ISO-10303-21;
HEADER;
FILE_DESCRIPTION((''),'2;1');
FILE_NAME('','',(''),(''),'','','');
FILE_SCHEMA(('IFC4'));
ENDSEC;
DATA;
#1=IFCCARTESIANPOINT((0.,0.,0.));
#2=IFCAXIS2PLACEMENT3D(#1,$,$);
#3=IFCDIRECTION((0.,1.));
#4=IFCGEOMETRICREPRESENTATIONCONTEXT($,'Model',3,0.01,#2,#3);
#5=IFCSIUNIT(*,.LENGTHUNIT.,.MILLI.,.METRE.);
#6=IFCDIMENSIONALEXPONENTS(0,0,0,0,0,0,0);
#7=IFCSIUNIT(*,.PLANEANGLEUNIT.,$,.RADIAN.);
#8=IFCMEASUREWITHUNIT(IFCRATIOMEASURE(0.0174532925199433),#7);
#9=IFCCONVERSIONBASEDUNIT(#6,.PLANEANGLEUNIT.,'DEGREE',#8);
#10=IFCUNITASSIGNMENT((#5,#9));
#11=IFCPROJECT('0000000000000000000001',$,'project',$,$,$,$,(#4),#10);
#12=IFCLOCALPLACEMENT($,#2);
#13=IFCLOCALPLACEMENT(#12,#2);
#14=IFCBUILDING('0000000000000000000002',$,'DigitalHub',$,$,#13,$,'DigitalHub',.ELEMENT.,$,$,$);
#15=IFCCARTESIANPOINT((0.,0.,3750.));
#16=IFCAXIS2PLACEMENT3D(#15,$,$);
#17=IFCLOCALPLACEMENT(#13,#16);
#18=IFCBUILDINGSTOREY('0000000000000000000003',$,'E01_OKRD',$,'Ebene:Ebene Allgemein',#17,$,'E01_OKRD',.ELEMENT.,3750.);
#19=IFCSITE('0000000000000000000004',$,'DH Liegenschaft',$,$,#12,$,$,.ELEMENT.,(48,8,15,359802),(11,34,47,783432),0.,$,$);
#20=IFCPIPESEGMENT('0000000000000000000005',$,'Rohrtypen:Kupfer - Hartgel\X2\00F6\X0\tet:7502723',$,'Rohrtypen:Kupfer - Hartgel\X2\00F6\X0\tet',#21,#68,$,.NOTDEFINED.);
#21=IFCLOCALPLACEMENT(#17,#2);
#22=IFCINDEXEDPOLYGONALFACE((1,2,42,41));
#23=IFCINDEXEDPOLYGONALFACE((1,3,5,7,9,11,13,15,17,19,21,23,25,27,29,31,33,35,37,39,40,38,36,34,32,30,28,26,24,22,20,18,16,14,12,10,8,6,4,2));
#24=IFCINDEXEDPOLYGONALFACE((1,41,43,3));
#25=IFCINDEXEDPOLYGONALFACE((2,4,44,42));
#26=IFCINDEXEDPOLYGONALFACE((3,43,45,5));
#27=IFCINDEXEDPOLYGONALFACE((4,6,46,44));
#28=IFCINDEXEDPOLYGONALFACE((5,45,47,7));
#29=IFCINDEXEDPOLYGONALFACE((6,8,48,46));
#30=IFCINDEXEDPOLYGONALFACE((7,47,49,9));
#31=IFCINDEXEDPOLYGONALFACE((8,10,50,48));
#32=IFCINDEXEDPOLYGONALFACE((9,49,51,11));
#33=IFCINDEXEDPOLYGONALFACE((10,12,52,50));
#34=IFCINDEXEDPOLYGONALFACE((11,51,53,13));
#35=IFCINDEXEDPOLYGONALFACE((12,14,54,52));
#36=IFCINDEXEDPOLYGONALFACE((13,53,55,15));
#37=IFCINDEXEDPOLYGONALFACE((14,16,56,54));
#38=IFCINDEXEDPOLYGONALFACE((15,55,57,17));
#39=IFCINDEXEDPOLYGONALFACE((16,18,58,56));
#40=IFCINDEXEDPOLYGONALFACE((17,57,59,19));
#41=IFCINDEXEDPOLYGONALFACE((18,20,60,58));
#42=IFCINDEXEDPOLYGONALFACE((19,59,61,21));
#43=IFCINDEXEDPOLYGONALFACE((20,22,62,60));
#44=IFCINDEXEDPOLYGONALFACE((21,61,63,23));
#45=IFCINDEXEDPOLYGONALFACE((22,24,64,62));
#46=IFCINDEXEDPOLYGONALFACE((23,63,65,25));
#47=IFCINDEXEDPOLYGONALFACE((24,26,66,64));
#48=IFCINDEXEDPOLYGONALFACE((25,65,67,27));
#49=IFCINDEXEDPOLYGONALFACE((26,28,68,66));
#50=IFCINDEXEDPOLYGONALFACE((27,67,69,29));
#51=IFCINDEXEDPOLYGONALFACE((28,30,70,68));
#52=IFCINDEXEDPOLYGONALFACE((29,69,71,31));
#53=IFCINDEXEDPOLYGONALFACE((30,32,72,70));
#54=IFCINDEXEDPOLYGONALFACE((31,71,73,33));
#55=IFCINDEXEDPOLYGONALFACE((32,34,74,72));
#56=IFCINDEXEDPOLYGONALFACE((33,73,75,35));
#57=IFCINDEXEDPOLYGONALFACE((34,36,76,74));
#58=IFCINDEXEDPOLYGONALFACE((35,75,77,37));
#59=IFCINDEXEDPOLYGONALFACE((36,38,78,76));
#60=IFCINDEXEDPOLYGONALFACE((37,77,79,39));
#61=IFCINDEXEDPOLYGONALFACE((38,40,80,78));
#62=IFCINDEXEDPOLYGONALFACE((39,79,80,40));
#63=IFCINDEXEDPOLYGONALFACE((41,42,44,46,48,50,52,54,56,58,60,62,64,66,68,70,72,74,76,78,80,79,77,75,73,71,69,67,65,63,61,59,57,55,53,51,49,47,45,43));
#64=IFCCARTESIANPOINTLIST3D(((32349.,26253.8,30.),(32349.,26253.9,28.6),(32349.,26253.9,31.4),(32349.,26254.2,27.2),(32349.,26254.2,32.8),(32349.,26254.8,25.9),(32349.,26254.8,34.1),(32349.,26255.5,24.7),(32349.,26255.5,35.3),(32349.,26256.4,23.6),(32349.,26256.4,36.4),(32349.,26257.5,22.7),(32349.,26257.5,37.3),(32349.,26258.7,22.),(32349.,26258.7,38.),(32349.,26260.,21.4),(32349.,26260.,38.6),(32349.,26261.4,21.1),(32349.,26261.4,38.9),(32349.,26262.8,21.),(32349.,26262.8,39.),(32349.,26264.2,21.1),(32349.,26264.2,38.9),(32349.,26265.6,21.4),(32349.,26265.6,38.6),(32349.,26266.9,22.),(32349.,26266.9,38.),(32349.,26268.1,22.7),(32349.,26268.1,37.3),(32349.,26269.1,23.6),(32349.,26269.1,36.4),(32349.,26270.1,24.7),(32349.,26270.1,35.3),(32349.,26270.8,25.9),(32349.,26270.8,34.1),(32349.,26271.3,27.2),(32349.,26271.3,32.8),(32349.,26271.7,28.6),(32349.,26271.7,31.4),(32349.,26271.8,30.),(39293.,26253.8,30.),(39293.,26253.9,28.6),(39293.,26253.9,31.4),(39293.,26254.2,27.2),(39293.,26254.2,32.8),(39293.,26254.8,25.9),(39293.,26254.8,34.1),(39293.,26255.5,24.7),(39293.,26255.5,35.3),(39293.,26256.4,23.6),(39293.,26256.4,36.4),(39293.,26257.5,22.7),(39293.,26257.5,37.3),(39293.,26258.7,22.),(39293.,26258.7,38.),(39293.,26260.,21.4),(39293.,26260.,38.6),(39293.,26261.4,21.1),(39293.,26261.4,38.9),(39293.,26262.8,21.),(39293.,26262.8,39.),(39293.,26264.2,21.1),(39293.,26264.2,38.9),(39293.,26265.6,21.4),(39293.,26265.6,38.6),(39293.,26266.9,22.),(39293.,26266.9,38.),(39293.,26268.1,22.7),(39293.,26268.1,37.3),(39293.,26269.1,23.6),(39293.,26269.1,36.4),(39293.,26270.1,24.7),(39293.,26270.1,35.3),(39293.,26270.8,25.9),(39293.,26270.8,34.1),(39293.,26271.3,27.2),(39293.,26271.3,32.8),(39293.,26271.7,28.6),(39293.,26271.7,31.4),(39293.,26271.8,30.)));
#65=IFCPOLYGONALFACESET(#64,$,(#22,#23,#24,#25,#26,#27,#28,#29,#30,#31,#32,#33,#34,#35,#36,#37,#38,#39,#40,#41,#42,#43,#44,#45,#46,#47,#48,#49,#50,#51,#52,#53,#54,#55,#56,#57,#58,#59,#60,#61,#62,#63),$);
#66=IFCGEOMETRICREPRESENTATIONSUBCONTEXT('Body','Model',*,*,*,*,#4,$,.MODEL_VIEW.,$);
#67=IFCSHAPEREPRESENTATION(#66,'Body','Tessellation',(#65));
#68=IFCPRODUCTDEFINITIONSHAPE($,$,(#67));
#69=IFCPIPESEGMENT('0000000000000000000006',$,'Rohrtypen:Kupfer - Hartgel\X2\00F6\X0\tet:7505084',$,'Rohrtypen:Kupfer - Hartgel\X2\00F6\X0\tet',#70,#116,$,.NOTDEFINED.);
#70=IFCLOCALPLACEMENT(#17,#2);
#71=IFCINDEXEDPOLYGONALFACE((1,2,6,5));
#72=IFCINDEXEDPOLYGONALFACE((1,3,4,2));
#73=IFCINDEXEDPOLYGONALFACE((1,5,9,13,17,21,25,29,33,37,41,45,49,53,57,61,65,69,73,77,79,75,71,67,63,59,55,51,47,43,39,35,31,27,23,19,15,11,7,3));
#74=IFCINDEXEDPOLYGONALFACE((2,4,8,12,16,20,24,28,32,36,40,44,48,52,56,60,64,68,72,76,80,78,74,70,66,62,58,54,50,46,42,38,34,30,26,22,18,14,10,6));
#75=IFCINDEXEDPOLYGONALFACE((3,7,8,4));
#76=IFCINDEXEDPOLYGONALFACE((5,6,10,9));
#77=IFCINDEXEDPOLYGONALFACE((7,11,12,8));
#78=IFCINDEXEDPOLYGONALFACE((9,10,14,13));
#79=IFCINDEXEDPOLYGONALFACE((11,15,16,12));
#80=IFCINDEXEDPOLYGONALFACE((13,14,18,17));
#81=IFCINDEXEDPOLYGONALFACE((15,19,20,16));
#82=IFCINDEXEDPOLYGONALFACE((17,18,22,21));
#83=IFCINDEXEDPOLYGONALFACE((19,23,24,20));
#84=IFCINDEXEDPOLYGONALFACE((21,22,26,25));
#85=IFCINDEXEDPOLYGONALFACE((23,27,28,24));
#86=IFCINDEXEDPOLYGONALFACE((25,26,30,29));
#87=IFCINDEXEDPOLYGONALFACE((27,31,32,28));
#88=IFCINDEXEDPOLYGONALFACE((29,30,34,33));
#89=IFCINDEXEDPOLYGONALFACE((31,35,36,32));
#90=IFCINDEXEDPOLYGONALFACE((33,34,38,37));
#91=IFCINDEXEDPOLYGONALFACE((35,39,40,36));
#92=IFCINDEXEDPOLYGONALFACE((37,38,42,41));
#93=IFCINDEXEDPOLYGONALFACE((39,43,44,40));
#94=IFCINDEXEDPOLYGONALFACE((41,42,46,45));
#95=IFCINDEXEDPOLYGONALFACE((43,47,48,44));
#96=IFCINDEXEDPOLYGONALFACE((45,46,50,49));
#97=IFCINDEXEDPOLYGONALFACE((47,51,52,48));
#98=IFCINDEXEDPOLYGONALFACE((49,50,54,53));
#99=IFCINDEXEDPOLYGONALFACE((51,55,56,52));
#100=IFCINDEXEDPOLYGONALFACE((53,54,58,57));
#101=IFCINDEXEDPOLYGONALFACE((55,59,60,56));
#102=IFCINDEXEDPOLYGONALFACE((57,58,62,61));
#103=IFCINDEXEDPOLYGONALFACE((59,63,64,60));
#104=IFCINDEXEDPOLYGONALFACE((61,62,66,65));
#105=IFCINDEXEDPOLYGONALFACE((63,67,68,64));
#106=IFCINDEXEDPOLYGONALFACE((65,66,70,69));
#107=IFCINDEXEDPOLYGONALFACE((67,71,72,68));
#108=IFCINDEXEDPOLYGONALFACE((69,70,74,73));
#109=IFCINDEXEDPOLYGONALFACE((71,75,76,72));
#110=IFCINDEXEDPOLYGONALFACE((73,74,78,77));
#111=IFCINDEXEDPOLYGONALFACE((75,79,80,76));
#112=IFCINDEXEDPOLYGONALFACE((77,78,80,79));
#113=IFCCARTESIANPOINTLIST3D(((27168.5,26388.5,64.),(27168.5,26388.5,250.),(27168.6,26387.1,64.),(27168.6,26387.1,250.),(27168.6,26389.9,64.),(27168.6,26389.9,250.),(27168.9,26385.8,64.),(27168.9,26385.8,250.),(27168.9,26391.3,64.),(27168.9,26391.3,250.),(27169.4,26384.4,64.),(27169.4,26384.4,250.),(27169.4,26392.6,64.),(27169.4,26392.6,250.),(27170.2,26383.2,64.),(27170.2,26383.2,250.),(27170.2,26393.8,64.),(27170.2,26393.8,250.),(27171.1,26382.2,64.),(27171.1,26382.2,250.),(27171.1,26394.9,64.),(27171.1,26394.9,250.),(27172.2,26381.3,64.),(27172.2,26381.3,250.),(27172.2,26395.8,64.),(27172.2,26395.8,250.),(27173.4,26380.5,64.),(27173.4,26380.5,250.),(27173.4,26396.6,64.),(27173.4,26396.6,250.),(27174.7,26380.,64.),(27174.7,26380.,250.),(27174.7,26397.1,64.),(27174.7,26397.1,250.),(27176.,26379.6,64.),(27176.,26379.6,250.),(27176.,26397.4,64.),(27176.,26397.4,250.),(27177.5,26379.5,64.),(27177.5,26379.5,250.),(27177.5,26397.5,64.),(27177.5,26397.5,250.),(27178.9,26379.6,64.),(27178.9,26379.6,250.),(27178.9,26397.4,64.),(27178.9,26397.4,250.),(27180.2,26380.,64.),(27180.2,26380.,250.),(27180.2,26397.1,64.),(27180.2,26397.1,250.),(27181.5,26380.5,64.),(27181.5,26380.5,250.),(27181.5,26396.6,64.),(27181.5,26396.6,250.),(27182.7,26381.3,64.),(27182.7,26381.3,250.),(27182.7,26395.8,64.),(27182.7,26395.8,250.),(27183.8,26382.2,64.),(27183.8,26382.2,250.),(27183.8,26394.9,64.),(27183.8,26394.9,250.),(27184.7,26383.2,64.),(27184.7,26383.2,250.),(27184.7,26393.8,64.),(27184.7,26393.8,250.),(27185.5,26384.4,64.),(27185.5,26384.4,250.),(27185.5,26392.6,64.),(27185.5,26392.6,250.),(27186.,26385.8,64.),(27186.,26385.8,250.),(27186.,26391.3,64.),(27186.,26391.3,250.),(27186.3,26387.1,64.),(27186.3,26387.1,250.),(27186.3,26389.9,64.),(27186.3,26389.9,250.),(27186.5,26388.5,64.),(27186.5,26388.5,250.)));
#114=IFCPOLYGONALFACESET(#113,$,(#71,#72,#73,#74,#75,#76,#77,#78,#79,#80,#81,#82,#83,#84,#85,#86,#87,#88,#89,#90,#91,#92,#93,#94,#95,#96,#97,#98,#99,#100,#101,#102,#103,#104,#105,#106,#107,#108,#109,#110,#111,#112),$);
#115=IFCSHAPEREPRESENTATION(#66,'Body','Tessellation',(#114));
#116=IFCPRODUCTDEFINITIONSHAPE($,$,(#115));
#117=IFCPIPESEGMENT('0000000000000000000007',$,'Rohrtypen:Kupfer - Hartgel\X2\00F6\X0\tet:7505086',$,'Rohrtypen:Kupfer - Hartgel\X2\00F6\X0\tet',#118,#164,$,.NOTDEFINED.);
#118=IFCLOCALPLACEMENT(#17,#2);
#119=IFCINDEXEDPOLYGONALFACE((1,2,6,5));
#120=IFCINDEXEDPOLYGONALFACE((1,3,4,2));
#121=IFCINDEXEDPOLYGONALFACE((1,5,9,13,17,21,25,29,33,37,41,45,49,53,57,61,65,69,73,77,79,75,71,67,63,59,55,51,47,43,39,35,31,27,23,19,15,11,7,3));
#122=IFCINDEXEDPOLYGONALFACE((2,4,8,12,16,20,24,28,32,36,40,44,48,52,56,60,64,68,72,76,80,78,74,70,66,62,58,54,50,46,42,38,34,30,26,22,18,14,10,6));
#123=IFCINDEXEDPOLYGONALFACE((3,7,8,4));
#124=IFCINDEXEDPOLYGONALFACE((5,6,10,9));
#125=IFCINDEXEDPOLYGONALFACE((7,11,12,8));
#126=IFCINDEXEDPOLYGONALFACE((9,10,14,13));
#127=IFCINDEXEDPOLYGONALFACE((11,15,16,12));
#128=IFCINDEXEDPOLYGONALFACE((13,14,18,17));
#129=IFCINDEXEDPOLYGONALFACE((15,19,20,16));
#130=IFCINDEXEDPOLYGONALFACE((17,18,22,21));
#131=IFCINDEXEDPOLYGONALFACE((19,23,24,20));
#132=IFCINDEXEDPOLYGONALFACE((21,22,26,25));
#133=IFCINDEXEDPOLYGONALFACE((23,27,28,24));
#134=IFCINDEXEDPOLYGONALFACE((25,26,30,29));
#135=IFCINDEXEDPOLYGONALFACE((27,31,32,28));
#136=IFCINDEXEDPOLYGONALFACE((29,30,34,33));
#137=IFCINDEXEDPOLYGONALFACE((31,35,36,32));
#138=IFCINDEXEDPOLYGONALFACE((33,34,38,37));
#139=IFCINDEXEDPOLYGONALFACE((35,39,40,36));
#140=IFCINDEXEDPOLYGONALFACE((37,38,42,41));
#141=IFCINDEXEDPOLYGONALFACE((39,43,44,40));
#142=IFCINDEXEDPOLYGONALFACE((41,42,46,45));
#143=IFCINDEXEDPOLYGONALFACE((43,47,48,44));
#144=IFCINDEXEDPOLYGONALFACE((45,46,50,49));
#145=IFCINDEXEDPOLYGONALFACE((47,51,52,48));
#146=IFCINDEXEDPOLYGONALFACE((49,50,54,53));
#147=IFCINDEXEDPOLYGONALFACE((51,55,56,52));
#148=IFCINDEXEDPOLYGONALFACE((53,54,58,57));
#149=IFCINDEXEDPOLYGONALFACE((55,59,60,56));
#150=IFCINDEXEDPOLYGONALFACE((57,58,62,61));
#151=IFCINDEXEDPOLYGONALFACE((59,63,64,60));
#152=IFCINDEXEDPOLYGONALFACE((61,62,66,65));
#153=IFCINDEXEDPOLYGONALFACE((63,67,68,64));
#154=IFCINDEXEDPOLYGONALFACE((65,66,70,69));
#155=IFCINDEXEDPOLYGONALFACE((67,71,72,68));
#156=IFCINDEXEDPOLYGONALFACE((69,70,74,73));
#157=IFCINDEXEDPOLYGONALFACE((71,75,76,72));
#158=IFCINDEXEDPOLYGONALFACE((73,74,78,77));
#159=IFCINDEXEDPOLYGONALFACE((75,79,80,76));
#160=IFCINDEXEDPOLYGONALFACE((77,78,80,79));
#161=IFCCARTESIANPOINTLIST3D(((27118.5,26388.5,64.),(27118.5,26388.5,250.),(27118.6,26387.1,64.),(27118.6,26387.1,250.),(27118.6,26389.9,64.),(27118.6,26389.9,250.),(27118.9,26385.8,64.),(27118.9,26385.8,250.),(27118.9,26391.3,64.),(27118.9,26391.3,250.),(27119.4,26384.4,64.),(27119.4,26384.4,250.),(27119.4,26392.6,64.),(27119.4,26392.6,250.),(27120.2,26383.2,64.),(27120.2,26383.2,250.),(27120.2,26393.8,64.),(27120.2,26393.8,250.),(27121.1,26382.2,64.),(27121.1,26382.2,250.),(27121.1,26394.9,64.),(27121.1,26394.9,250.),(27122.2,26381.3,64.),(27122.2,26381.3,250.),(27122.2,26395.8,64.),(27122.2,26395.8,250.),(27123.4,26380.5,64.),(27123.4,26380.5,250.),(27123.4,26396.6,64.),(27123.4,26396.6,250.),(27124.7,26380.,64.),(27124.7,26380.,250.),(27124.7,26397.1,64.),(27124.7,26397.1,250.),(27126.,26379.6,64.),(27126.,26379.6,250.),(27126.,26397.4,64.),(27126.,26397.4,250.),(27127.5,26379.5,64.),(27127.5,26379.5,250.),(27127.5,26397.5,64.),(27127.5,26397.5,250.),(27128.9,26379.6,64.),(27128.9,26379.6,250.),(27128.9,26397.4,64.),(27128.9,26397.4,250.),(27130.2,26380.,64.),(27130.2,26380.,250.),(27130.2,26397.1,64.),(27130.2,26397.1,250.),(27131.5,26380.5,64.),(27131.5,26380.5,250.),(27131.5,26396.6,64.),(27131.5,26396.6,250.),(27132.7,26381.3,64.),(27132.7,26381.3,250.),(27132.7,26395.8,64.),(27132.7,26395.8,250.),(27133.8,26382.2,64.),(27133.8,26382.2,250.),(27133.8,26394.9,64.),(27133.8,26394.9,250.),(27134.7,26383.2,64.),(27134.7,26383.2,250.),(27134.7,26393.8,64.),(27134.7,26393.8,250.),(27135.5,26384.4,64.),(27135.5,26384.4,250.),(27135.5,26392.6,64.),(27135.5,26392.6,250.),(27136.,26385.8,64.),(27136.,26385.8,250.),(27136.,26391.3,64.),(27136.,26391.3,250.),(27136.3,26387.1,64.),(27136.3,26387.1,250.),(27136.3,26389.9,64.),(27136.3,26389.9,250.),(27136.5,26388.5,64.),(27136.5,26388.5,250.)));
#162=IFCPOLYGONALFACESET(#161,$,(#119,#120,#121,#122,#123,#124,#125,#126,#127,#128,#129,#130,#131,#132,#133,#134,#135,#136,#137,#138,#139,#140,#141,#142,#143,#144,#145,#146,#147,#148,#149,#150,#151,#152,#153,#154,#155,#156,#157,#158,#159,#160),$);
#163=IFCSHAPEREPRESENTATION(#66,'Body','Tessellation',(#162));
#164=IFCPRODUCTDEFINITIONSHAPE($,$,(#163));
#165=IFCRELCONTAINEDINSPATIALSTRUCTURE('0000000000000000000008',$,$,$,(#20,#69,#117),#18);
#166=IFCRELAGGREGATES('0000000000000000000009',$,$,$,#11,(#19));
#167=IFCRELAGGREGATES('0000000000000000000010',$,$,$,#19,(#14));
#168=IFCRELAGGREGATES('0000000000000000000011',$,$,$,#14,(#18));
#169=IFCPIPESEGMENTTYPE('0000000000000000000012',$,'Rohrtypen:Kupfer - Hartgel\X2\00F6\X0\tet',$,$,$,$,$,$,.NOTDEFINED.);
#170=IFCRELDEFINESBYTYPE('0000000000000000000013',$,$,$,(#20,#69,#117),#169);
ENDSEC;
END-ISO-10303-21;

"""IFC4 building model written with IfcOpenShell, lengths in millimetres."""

from ifc_helpers import new_model, entity, si_unit, converted_unit, direction, frame, origin, place, context, subcontext, project, spatial, indexed_curve, outline, extrude, type_object, element, save


model = new_model("IFC4")

# Units and contexts
model_context = context("Model", 3, precision=0.01, world=origin(), true_north=direction((0.0, 1.0)))
body_context = subcontext(model_context, "Body", "Model", "MODEL_VIEW")
ifc_project = project(units=[si_unit("LENGTHUNIT", "METRE", prefix="MILLI"), converted_unit("PLANEANGLEUNIT", "DEGREE", entity("IfcRatioMeasure", 0.0174532925199433), si_unit("PLANEANGLEUNIT", "RADIAN"), dimensions=[0, 0, 0, 0, 0, 0, 0])], contexts=[model_context])

# Site, building, storey
site_placement = place(None, origin())
site = spatial("IfcSite", under=ifc_project, at=site_placement, Name="DH Liegenschaft", CompositionType="ELEMENT", RefLatitude=(48, 8, 15, 359802), RefLongitude=(11, 34, 47, 783432), RefElevation=0.0)
building_placement = place(site_placement, origin())
building = spatial("IfcBuilding", under=site, at=building_placement, Name="DigitalHub", LongName="DigitalHub", CompositionType="ELEMENT")
storey_placement = place(building_placement, frame((0.0, 0.0, 3750.0)))
storey = spatial("IfcBuildingStorey", under=building, at=storey_placement, Name="E01_OKRD", ObjectType="Ebene:Ebene Allgemein", LongName="E01_OKRD", CompositionType="ELEMENT", Elevation=3750.0)

# Pipe segments
pipe_segment_type = type_object("IfcPipeSegmentType", Name="Rohrtypen:Kupfer - Hartgelötet", PredefinedType="NOTDEFINED")
pipe_segment_1_placement = place(storey_placement, frame((32349.0, 26252.2, 19.4)))
element("IfcPipeSegment", 1, at=pipe_segment_1_placement, inside=storey, type_object=pipe_segment_type, Name="Rohrtypen:Kupfer - Hartgelötet:7502723", ObjectType="Rohrtypen:Kupfer - Hartgelötet", PredefinedType="NOTDEFINED", context=body_context, shape_type="SweptSolid", body=[
    extrude(outline(indexed_curve([(9.0, 0.0), (8.9, 1.4), (8.6, 2.8), (8.0, 4.1), (7.3, 5.3), (6.4, 6.4), (5.3, 7.3), (4.1, 8.0), (2.8, 8.6), (1.4, 8.9), (0.0, 9.0), (-1.4, 8.9), (-2.8, 8.6), (-4.1, 8.0), (-5.3, 7.3), (-6.4, 6.4), (-7.3, 5.3), (-8.0, 4.1), (-8.6, 2.8), (-8.9, 1.4), (-9.0, 0.0), (-8.9, -1.4), (-8.6, -2.8), (-8.0, -4.1), (-7.3, -5.3), (-6.4, -6.4), (-5.3, -7.3), (-4.1, -8.0), (-2.8, -8.6), (-1.4, -8.9), (0.0, -9.0), (1.4, -8.9), (2.8, -8.6), (4.1, -8.0), (5.3, -7.3), (6.4, -6.4), (7.3, -5.3), (8.0, -4.1), (8.6, -2.8), (8.9, -1.4), (9.0, 0.0)], self_intersect=False)), frame((0.0, 10.6, 10.6), z_axis=(1.0, 0.0, 0.0), x_axis=(0.0, 1.0, 0.0)), (0.0, 0.0, 1.0), 6944.0),
])
pipe_segment_2_placement = place(storey_placement, frame((27166.9, 26377.9, 64.0)))
element("IfcPipeSegment", 2, at=pipe_segment_2_placement, inside=storey, type_object=pipe_segment_type, Name="Rohrtypen:Kupfer - Hartgelötet:7505084", ObjectType="Rohrtypen:Kupfer - Hartgelötet", PredefinedType="NOTDEFINED", context=body_context, shape_type="SweptSolid", body=[
    extrude(outline(indexed_curve([(9.0, 0.0), (8.9, 1.4), (8.6, 2.8), (8.0, 4.1), (7.3, 5.3), (6.4, 6.4), (5.3, 7.3), (4.1, 8.0), (2.8, 8.6), (1.4, 8.9), (0.0, 9.0), (-1.4, 8.9), (-2.8, 8.6), (-4.1, 8.0), (-5.3, 7.3), (-6.4, 6.4), (-7.3, 5.3), (-8.0, 4.1), (-8.6, 2.8), (-8.9, 1.4), (-9.0, 0.0), (-8.9, -1.4), (-8.6, -2.8), (-8.0, -4.1), (-7.3, -5.3), (-6.4, -6.4), (-5.3, -7.3), (-4.1, -8.0), (-2.8, -8.6), (-1.4, -8.9), (0.0, -9.0), (1.4, -8.9), (2.8, -8.6), (4.1, -8.0), (5.3, -7.3), (6.4, -6.4), (7.3, -5.3), (8.0, -4.1), (8.6, -2.8), (8.9, -1.4), (9.0, 0.0)], self_intersect=False)), frame((10.6, 10.6, 0.0)), (0.0, 0.0, 1.0), 186.0),
])
pipe_segment_3_placement = place(storey_placement, frame((27116.9, 26377.9, 64.0)))
element("IfcPipeSegment", 3, at=pipe_segment_3_placement, inside=storey, type_object=pipe_segment_type, Name="Rohrtypen:Kupfer - Hartgelötet:7505086", ObjectType="Rohrtypen:Kupfer - Hartgelötet", PredefinedType="NOTDEFINED", context=body_context, shape_type="SweptSolid", body=[
    extrude(outline(indexed_curve([(9.0, 0.0), (8.9, 1.4), (8.6, 2.8), (8.0, 4.1), (7.3, 5.3), (6.4, 6.4), (5.3, 7.3), (4.1, 8.0), (2.8, 8.6), (1.4, 8.9), (0.0, 9.0), (-1.4, 8.9), (-2.8, 8.6), (-4.1, 8.0), (-5.3, 7.3), (-6.4, 6.4), (-7.3, 5.3), (-8.0, 4.1), (-8.6, 2.8), (-8.9, 1.4), (-9.0, 0.0), (-8.9, -1.4), (-8.6, -2.8), (-8.0, -4.1), (-7.3, -5.3), (-6.4, -6.4), (-5.3, -7.3), (-4.1, -8.0), (-2.8, -8.6), (-1.4, -8.9), (0.0, -9.0), (1.4, -8.9), (2.8, -8.6), (4.1, -8.0), (5.3, -7.3), (6.4, -6.4), (7.3, -5.3), (8.0, -4.1), (8.6, -2.8), (8.9, -1.4), (9.0, 0.0)], self_intersect=False)), frame((10.6, 10.6, 0.0)), (0.0, 0.0, 1.0), 186.0),
])

save(model, "model.ifc")
